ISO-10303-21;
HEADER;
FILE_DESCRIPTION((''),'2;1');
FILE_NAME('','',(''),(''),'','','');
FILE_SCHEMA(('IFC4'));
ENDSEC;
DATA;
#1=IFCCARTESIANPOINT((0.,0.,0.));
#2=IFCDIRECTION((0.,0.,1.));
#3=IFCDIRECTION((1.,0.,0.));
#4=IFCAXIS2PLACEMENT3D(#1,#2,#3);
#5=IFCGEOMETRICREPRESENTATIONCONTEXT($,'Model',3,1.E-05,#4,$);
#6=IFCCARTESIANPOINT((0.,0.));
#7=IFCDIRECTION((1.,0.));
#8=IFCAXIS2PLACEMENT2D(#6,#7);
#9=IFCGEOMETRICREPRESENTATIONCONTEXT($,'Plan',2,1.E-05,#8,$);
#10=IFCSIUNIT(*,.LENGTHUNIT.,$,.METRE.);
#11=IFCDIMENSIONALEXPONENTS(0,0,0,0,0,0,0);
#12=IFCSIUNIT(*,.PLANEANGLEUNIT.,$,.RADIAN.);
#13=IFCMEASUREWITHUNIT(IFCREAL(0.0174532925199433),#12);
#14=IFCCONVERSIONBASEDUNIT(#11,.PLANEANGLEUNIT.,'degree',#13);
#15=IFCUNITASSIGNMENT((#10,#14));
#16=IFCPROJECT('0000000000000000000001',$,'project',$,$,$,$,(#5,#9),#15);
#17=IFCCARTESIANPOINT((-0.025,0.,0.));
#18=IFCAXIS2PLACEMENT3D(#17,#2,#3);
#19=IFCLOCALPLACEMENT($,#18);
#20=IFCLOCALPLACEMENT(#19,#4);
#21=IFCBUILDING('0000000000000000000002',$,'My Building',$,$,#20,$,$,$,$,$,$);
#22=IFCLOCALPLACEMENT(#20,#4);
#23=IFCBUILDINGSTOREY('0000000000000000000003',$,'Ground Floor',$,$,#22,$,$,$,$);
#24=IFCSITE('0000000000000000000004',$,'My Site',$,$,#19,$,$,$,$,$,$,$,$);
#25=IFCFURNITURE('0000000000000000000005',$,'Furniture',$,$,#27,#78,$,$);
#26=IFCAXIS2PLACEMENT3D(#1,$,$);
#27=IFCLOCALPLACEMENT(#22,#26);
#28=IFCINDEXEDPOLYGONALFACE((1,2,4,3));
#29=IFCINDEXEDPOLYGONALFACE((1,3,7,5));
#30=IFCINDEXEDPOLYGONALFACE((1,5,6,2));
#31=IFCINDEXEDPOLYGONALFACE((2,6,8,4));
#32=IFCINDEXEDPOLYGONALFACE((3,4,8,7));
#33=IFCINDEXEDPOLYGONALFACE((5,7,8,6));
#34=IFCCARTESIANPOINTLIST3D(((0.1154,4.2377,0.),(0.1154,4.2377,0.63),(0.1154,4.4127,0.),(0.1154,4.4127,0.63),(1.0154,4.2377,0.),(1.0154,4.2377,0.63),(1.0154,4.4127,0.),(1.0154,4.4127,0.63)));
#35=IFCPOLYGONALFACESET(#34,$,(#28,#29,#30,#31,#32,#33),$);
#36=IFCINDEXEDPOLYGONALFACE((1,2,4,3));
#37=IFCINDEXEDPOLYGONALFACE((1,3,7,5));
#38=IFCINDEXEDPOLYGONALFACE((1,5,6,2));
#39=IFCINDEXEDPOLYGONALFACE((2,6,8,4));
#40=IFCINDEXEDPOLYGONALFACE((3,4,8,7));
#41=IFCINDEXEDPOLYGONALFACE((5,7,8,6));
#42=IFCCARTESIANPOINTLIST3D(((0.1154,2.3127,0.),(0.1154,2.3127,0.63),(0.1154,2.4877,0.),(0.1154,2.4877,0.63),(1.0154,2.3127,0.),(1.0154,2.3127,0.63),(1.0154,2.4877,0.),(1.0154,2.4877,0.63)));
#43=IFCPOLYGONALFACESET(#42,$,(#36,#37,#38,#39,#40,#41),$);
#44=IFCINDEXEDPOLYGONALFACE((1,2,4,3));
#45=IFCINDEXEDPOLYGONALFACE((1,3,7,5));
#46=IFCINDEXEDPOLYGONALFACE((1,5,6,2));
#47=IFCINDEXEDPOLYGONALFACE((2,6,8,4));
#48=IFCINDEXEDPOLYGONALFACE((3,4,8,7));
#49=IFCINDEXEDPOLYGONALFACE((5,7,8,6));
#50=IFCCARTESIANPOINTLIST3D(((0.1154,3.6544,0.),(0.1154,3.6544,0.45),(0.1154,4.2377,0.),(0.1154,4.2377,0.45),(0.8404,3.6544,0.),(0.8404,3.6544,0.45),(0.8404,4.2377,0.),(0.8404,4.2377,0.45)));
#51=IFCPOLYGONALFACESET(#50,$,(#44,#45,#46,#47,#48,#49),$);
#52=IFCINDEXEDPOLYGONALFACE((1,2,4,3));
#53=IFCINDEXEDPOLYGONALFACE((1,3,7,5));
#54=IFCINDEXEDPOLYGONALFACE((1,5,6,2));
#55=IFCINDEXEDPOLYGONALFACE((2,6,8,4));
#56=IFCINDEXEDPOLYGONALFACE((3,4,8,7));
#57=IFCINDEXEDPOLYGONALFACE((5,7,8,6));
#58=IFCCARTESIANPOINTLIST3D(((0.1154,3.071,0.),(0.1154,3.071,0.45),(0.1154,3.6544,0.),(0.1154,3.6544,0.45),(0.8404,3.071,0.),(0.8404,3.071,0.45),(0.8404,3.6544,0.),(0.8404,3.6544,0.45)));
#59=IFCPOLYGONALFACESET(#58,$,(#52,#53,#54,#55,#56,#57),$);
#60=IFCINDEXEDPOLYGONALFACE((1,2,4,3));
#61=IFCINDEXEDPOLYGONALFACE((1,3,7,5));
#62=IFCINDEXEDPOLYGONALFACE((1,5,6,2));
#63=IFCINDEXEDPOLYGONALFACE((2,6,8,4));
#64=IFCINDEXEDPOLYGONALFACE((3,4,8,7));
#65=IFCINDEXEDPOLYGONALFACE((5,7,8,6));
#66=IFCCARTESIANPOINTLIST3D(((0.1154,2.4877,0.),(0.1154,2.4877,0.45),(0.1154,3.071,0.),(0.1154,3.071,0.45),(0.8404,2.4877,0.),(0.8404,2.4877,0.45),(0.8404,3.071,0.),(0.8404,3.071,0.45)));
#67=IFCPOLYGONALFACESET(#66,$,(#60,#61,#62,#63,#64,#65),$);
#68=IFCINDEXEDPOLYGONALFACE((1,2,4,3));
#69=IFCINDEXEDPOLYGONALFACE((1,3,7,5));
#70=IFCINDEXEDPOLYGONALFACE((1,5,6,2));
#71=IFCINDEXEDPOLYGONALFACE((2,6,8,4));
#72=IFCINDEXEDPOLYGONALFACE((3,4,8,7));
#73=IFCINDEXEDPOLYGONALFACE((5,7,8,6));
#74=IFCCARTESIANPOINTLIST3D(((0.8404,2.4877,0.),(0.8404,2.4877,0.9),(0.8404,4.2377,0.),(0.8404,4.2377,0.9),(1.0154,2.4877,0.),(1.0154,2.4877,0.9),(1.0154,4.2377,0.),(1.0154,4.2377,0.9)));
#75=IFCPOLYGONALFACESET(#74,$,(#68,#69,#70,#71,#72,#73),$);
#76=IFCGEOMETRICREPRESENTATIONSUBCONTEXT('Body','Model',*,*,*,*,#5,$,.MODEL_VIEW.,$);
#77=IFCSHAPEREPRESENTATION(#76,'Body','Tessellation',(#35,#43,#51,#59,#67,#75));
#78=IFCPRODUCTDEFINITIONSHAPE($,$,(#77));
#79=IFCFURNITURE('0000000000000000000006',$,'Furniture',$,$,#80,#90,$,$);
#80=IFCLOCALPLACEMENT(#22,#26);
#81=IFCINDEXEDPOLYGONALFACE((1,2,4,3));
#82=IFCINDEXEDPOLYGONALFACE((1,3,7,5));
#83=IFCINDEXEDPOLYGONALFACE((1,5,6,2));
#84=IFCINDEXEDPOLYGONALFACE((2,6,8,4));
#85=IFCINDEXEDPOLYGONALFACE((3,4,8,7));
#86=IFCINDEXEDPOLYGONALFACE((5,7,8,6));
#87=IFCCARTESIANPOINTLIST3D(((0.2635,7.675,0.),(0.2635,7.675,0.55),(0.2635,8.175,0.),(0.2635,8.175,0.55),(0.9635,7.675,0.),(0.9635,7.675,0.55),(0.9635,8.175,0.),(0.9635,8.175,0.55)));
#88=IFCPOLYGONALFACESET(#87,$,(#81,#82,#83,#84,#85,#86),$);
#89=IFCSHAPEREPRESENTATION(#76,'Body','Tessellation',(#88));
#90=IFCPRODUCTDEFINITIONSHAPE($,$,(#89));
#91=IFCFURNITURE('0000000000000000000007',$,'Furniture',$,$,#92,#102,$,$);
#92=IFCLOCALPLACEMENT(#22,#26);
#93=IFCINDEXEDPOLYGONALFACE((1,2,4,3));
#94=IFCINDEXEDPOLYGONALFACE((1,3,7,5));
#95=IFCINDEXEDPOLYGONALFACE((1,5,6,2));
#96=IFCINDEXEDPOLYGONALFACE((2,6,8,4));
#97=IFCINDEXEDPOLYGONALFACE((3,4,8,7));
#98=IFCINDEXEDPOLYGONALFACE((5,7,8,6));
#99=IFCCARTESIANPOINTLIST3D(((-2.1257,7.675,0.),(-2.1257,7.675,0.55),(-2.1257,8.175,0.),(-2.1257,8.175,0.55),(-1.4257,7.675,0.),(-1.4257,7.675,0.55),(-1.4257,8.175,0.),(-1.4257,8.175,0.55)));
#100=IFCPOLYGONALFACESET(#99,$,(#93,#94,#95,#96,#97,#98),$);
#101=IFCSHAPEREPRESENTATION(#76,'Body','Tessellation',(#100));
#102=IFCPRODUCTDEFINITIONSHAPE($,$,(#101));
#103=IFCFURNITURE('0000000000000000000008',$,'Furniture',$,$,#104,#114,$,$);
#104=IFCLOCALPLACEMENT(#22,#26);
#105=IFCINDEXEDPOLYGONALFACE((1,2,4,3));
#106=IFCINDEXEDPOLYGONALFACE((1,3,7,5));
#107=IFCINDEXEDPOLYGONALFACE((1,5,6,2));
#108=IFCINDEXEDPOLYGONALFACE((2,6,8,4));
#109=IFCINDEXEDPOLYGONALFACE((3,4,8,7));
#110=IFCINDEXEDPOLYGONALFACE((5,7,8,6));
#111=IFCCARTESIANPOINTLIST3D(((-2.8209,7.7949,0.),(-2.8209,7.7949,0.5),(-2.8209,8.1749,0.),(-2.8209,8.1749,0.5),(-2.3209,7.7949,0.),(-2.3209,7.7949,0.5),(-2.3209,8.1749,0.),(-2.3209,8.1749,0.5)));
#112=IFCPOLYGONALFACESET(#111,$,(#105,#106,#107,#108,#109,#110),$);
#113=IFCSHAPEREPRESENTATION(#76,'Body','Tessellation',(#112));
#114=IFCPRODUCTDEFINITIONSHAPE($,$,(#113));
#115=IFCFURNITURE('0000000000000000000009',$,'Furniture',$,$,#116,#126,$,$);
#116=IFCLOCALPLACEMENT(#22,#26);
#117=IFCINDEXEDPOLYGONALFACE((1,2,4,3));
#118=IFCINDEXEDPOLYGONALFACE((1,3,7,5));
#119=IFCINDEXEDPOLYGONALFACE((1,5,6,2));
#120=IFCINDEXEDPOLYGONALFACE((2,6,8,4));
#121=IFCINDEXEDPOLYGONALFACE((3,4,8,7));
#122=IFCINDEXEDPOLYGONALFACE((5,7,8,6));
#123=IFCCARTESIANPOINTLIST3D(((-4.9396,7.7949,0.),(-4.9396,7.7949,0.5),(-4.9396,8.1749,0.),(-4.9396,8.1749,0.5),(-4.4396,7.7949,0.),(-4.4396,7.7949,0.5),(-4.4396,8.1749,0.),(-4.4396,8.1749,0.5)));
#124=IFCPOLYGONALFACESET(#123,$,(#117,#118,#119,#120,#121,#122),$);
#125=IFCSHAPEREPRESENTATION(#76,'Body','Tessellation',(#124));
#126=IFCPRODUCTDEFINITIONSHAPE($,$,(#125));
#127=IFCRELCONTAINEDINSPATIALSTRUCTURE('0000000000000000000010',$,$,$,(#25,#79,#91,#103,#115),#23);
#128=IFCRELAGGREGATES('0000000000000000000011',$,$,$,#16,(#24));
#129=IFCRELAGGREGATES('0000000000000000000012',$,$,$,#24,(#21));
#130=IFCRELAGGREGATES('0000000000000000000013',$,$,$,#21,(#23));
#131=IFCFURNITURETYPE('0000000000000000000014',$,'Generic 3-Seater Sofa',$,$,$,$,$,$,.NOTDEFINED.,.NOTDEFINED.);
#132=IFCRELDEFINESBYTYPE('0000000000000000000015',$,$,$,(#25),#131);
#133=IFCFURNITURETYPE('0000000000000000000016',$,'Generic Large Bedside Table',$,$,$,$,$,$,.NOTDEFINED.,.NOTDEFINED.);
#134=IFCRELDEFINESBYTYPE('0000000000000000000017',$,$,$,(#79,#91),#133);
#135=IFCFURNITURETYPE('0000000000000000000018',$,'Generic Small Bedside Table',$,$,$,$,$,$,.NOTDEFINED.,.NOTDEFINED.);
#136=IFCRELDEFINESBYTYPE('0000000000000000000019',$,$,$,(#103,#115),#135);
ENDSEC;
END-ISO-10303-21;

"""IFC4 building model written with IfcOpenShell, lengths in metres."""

from ifc_helpers import new_model, entity, si_unit, converted_unit, frame, origin_with_axes, origin_2d_with_axis, place, context, subcontext, project, spatial, line, indexed_curve, outline, extrude, shape, source, transform, mapped, type_object, type_shapes, element, save


model = new_model("IFC4")

# Units and contexts
model_context = context("Model", 3, precision=1e-05, world=origin_with_axes())
plan_context = context("Plan", 2, precision=1e-05, world=origin_2d_with_axis())
body_context_1 = subcontext(model_context, "Body", "Model", "MODEL_VIEW")
body_context_2 = subcontext(plan_context, "Body", "Plan", "PLAN_VIEW")
ifc_project = project(units=[si_unit("LENGTHUNIT", "METRE"), converted_unit("PLANEANGLEUNIT", "degree", entity("IfcReal", 0.0174532925199433), si_unit("PLANEANGLEUNIT", "RADIAN"), dimensions=[0, 0, 0, 0, 0, 0, 0])], contexts=[model_context, plan_context])

# Site, building, storey
site_placement = place(None, frame((-0.025, 0.0, 0.0), z_axis=(0.0, 0.0, 1.0), x_axis=(1.0, 0.0, 0.0)))
site = spatial("IfcSite", under=ifc_project, at=site_placement, Name="My Site")
building_placement = place(site_placement, origin_with_axes())
building = spatial("IfcBuilding", under=site, at=building_placement, Name="My Building")
storey_placement = place(building_placement, frame((0.0, 0.0, 0.0), z_axis=(0.0, 0.0, 1.0), x_axis=(1.0, 0.0, 0.0)))
storey = spatial("IfcBuildingStorey", under=building, at=storey_placement, Name="Ground Floor")

# Furniture
furniture_type_1 = type_object("IfcFurnitureType", Name="Generic 3-Seater Sofa", AssemblyPlace="NOTDEFINED", PredefinedType="NOTDEFINED")
shared_shape_1 = source(origin_with_axes(), body_context_1, "Body", "SweptSolid", [
    extrude(outline(indexed_curve([(0.0, 0.0), (0.175, 0.0), (0.175, 0.9), (0.0, 0.9)], segments=[line(1, 2, 3, 4, 1)])), frame((-1.05, -0.9, 0.0), z_axis=(0.0, 0.0, 1.0), x_axis=(1.0, 0.0, 0.0)), (0.0, 0.0, 1.0), 0.63),
    extrude(outline(indexed_curve([(0.0, 0.0), (0.175, 0.0), (0.175, 0.9), (0.0, 0.9)], segments=[line(1, 2, 3, 4, 1)])), frame((0.875, -0.9, 0.0), z_axis=(0.0, 0.0, 1.0), x_axis=(1.0, 0.0, 0.0)), (0.0, 0.0, 1.0), 0.63),
    extrude(outline(indexed_curve([(0.175, 0.0), (0.7583, 0.0), (0.7583, 0.725), (0.175, 0.725)], segments=[line(1, 2, 3, 4, 1)])), frame((-1.05, -0.9, 0.0), z_axis=(0.0, 0.0, 1.0), x_axis=(1.0, 0.0, 0.0)), (0.0, 0.0, 1.0), 0.45),
    extrude(outline(indexed_curve([(0.7583, 0.0), (1.3417, 0.0), (1.3417, 0.725), (0.7583, 0.725)], segments=[line(1, 2, 3, 4, 1)])), frame((-1.05, -0.9, 0.0), z_axis=(0.0, 0.0, 1.0), x_axis=(1.0, 0.0, 0.0)), (0.0, 0.0, 1.0), 0.45),
    extrude(outline(indexed_curve([(1.3417, 0.0), (1.925, 0.0), (1.925, 0.725), (1.3417, 0.725)], segments=[line(1, 2, 3, 4, 1)])), frame((-1.05, -0.9, 0.0), z_axis=(0.0, 0.0, 1.0), x_axis=(1.0, 0.0, 0.0)), (0.0, 0.0, 1.0), 0.45),
    extrude(outline(indexed_curve([(0.175, 0.725), (1.925, 0.725), (1.925, 0.9), (0.175, 0.9)], segments=[line(1, 2, 3, 4, 1)])), frame((-1.05, -0.9, 0.0), z_axis=(0.0, 0.0, 1.0), x_axis=(1.0, 0.0, 0.0)), (0.0, 0.0, 1.0), 0.9),
])
shared_shape_2 = source(origin_with_axes(), body_context_2, "Body", "Curve2D", [
    entity("IfcIndexedPolyCurve", entity("IfcCartesianPointList2D", [[-1.05, -0.9], [-0.875, -0.9], [-0.875, 0.0], [-1.05, 0.0]]), [entity("IfcLineIndex", [1, 2, 3, 4, 1])]),
    entity("IfcIndexedPolyCurve", entity("IfcCartesianPointList2D", [[0.875, -0.9], [1.05, -0.9], [1.05, 0.0], [0.875, 0.0]]), [entity("IfcLineIndex", [1, 2, 3, 4, 1])]),
    entity("IfcIndexedPolyCurve", entity("IfcCartesianPointList2D", [[-0.875, -0.9], [-0.2917, -0.9], [-0.2917, -0.175], [-0.875, -0.175]]), [entity("IfcLineIndex", [1, 2, 3, 4, 1])]),
    entity("IfcIndexedPolyCurve", entity("IfcCartesianPointList2D", [[-0.2917, -0.9], [0.2917, -0.9], [0.2917, -0.175], [-0.2917, -0.175]]), [entity("IfcLineIndex", [1, 2, 3, 4, 1])]),
    entity("IfcIndexedPolyCurve", entity("IfcCartesianPointList2D", [[0.2917, -0.9], [0.875, -0.9], [0.875, -0.175], [0.2917, -0.175]]), [entity("IfcLineIndex", [1, 2, 3, 4, 1])]),
    entity("IfcIndexedPolyCurve", entity("IfcCartesianPointList2D", [[-0.875, -0.175], [0.875, -0.175], [0.875, 0.0], [-0.875, 0.0]]), [entity("IfcLineIndex", [1, 2, 3, 4, 1])]),
])
type_shapes(furniture_type_1, [shared_shape_1, shared_shape_2])
furniture_1_placement = place(storey_placement, frame((1.0154, 3.3627, 0.0), z_axis=(0.0, 0.0, 1.0), x_axis=(0.0, -1.0, 0.0)))
element("IfcFurniture", 1, at=furniture_1_placement, inside=storey, type_object=furniture_type_1, Name="Furniture", shapes=[
    shape(body_context_1, "Body", "MappedRepresentation", [mapped(shared_shape_1, transform((0.0, 0.0, 0.0), x_axis=(1.0, 0.0, 0.0), y_axis=(0.0, 1.0, 0.0), z_axis=(0.0, 0.0, 1.0), scale=1.0))]),
    shape(body_context_2, "Body", "MappedRepresentation", [mapped(shared_shape_2, transform((0.0, 0.0, 0.0), x_axis=(1.0, 0.0, 0.0), y_axis=(0.0, 1.0, 0.0), z_axis=(0.0, 0.0, 1.0), scale=1.0))]),
])
furniture_type_2 = type_object("IfcFurnitureType", Name="Generic Large Bedside Table", AssemblyPlace="NOTDEFINED", PredefinedType="NOTDEFINED")
shared_shape_3 = source(origin_with_axes(), body_context_1, "Body", "SweptSolid", [
    extrude(outline(indexed_curve([(0.0, 0.0), (0.7, 0.0), (0.7, 0.5), (0.0, 0.5)], segments=[line(1, 2, 3, 4, 1)])), frame((-0.35, -0.25, 0.0), z_axis=(0.0, 0.0, 1.0), x_axis=(1.0, 0.0, 0.0)), (0.0, 0.0, 1.0), 0.55),
])
shared_shape_4 = source(origin_with_axes(), body_context_2, "Body", "Curve2D", [
    entity("IfcIndexedPolyCurve", entity("IfcCartesianPointList2D", [[-0.35, -0.25], [0.35, -0.25], [0.35, 0.25], [-0.35, 0.25]]), [entity("IfcLineIndex", [1, 2, 3, 4, 1])]),
])
type_shapes(furniture_type_2, [shared_shape_3, shared_shape_4])
for number, where, z_axis, x_axis, name in (
    (2, (0.6135, 7.925, 0.0), (0.0, 0.0, 1.0), (1.0, 0.0, 0.0), "Furniture"),
    (3, (-1.7757, 7.925, 0.0), (0.0, 0.0, 1.0), (1.0, 0.0, 0.0), "Furniture"),
):
    element("IfcFurniture", number, at=place(storey_placement, frame(where, z_axis=z_axis, x_axis=x_axis)), inside=storey, type_object=furniture_type_2, Name=name, shapes=[
        shape(body_context_1, "Body", "MappedRepresentation", [mapped(shared_shape_3, transform((0.0, 0.0, 0.0), x_axis=(1.0, 0.0, 0.0), y_axis=(0.0, 1.0, 0.0), z_axis=(0.0, 0.0, 1.0), scale=1.0))]),
        shape(body_context_2, "Body", "MappedRepresentation", [mapped(shared_shape_4, transform((0.0, 0.0, 0.0), x_axis=(1.0, 0.0, 0.0), y_axis=(0.0, 1.0, 0.0), z_axis=(0.0, 0.0, 1.0), scale=1.0))]),
    ])
furniture_type_3 = type_object("IfcFurnitureType", Name="Generic Small Bedside Table", AssemblyPlace="NOTDEFINED", PredefinedType="NOTDEFINED")
shared_shape_5 = source(origin_with_axes(), body_context_1, "Body", "SweptSolid", [
    extrude(outline(indexed_curve([(0.0, 0.0), (0.5, 0.0), (0.5, 0.38), (0.0, 0.38)], segments=[line(1, 2, 3, 4, 1)])), frame((-0.25, -0.19, 0.0), z_axis=(0.0, 0.0, 1.0), x_axis=(1.0, 0.0, 0.0)), (0.0, 0.0, 1.0), 0.5),
])
shared_shape_6 = source(origin_with_axes(), body_context_2, "Body", "Curve2D", [
    entity("IfcIndexedPolyCurve", entity("IfcCartesianPointList2D", [[-0.25, -0.19], [0.25, -0.19], [0.25, 0.19], [-0.25, 0.19]]), [entity("IfcLineIndex", [1, 2, 3, 4, 1])]),
])
type_shapes(furniture_type_3, [shared_shape_5, shared_shape_6])
for number, where, z_axis, x_axis, name in (
    (4, (-2.5709, 7.9849, 0.0), (0.0, 0.0, 1.0), (1.0, 0.0, 0.0), "Furniture"),
    (5, (-4.6896, 7.9849, 0.0), (0.0, 0.0, 1.0), (1.0, 0.0, 0.0), "Furniture"),
):
    element("IfcFurniture", number, at=place(storey_placement, frame(where, z_axis=z_axis, x_axis=x_axis)), inside=storey, type_object=furniture_type_3, Name=name, shapes=[
        shape(body_context_1, "Body", "MappedRepresentation", [mapped(shared_shape_5, transform((0.0, 0.0, 0.0), x_axis=(1.0, 0.0, 0.0), y_axis=(0.0, 1.0, 0.0), z_axis=(0.0, 0.0, 1.0), scale=1.0))]),
        shape(body_context_2, "Body", "MappedRepresentation", [mapped(shared_shape_6, transform((0.0, 0.0, 0.0), x_axis=(1.0, 0.0, 0.0), y_axis=(0.0, 1.0, 0.0), z_axis=(0.0, 0.0, 1.0), scale=1.0))]),
    ])

save(model, "model.ifc")
